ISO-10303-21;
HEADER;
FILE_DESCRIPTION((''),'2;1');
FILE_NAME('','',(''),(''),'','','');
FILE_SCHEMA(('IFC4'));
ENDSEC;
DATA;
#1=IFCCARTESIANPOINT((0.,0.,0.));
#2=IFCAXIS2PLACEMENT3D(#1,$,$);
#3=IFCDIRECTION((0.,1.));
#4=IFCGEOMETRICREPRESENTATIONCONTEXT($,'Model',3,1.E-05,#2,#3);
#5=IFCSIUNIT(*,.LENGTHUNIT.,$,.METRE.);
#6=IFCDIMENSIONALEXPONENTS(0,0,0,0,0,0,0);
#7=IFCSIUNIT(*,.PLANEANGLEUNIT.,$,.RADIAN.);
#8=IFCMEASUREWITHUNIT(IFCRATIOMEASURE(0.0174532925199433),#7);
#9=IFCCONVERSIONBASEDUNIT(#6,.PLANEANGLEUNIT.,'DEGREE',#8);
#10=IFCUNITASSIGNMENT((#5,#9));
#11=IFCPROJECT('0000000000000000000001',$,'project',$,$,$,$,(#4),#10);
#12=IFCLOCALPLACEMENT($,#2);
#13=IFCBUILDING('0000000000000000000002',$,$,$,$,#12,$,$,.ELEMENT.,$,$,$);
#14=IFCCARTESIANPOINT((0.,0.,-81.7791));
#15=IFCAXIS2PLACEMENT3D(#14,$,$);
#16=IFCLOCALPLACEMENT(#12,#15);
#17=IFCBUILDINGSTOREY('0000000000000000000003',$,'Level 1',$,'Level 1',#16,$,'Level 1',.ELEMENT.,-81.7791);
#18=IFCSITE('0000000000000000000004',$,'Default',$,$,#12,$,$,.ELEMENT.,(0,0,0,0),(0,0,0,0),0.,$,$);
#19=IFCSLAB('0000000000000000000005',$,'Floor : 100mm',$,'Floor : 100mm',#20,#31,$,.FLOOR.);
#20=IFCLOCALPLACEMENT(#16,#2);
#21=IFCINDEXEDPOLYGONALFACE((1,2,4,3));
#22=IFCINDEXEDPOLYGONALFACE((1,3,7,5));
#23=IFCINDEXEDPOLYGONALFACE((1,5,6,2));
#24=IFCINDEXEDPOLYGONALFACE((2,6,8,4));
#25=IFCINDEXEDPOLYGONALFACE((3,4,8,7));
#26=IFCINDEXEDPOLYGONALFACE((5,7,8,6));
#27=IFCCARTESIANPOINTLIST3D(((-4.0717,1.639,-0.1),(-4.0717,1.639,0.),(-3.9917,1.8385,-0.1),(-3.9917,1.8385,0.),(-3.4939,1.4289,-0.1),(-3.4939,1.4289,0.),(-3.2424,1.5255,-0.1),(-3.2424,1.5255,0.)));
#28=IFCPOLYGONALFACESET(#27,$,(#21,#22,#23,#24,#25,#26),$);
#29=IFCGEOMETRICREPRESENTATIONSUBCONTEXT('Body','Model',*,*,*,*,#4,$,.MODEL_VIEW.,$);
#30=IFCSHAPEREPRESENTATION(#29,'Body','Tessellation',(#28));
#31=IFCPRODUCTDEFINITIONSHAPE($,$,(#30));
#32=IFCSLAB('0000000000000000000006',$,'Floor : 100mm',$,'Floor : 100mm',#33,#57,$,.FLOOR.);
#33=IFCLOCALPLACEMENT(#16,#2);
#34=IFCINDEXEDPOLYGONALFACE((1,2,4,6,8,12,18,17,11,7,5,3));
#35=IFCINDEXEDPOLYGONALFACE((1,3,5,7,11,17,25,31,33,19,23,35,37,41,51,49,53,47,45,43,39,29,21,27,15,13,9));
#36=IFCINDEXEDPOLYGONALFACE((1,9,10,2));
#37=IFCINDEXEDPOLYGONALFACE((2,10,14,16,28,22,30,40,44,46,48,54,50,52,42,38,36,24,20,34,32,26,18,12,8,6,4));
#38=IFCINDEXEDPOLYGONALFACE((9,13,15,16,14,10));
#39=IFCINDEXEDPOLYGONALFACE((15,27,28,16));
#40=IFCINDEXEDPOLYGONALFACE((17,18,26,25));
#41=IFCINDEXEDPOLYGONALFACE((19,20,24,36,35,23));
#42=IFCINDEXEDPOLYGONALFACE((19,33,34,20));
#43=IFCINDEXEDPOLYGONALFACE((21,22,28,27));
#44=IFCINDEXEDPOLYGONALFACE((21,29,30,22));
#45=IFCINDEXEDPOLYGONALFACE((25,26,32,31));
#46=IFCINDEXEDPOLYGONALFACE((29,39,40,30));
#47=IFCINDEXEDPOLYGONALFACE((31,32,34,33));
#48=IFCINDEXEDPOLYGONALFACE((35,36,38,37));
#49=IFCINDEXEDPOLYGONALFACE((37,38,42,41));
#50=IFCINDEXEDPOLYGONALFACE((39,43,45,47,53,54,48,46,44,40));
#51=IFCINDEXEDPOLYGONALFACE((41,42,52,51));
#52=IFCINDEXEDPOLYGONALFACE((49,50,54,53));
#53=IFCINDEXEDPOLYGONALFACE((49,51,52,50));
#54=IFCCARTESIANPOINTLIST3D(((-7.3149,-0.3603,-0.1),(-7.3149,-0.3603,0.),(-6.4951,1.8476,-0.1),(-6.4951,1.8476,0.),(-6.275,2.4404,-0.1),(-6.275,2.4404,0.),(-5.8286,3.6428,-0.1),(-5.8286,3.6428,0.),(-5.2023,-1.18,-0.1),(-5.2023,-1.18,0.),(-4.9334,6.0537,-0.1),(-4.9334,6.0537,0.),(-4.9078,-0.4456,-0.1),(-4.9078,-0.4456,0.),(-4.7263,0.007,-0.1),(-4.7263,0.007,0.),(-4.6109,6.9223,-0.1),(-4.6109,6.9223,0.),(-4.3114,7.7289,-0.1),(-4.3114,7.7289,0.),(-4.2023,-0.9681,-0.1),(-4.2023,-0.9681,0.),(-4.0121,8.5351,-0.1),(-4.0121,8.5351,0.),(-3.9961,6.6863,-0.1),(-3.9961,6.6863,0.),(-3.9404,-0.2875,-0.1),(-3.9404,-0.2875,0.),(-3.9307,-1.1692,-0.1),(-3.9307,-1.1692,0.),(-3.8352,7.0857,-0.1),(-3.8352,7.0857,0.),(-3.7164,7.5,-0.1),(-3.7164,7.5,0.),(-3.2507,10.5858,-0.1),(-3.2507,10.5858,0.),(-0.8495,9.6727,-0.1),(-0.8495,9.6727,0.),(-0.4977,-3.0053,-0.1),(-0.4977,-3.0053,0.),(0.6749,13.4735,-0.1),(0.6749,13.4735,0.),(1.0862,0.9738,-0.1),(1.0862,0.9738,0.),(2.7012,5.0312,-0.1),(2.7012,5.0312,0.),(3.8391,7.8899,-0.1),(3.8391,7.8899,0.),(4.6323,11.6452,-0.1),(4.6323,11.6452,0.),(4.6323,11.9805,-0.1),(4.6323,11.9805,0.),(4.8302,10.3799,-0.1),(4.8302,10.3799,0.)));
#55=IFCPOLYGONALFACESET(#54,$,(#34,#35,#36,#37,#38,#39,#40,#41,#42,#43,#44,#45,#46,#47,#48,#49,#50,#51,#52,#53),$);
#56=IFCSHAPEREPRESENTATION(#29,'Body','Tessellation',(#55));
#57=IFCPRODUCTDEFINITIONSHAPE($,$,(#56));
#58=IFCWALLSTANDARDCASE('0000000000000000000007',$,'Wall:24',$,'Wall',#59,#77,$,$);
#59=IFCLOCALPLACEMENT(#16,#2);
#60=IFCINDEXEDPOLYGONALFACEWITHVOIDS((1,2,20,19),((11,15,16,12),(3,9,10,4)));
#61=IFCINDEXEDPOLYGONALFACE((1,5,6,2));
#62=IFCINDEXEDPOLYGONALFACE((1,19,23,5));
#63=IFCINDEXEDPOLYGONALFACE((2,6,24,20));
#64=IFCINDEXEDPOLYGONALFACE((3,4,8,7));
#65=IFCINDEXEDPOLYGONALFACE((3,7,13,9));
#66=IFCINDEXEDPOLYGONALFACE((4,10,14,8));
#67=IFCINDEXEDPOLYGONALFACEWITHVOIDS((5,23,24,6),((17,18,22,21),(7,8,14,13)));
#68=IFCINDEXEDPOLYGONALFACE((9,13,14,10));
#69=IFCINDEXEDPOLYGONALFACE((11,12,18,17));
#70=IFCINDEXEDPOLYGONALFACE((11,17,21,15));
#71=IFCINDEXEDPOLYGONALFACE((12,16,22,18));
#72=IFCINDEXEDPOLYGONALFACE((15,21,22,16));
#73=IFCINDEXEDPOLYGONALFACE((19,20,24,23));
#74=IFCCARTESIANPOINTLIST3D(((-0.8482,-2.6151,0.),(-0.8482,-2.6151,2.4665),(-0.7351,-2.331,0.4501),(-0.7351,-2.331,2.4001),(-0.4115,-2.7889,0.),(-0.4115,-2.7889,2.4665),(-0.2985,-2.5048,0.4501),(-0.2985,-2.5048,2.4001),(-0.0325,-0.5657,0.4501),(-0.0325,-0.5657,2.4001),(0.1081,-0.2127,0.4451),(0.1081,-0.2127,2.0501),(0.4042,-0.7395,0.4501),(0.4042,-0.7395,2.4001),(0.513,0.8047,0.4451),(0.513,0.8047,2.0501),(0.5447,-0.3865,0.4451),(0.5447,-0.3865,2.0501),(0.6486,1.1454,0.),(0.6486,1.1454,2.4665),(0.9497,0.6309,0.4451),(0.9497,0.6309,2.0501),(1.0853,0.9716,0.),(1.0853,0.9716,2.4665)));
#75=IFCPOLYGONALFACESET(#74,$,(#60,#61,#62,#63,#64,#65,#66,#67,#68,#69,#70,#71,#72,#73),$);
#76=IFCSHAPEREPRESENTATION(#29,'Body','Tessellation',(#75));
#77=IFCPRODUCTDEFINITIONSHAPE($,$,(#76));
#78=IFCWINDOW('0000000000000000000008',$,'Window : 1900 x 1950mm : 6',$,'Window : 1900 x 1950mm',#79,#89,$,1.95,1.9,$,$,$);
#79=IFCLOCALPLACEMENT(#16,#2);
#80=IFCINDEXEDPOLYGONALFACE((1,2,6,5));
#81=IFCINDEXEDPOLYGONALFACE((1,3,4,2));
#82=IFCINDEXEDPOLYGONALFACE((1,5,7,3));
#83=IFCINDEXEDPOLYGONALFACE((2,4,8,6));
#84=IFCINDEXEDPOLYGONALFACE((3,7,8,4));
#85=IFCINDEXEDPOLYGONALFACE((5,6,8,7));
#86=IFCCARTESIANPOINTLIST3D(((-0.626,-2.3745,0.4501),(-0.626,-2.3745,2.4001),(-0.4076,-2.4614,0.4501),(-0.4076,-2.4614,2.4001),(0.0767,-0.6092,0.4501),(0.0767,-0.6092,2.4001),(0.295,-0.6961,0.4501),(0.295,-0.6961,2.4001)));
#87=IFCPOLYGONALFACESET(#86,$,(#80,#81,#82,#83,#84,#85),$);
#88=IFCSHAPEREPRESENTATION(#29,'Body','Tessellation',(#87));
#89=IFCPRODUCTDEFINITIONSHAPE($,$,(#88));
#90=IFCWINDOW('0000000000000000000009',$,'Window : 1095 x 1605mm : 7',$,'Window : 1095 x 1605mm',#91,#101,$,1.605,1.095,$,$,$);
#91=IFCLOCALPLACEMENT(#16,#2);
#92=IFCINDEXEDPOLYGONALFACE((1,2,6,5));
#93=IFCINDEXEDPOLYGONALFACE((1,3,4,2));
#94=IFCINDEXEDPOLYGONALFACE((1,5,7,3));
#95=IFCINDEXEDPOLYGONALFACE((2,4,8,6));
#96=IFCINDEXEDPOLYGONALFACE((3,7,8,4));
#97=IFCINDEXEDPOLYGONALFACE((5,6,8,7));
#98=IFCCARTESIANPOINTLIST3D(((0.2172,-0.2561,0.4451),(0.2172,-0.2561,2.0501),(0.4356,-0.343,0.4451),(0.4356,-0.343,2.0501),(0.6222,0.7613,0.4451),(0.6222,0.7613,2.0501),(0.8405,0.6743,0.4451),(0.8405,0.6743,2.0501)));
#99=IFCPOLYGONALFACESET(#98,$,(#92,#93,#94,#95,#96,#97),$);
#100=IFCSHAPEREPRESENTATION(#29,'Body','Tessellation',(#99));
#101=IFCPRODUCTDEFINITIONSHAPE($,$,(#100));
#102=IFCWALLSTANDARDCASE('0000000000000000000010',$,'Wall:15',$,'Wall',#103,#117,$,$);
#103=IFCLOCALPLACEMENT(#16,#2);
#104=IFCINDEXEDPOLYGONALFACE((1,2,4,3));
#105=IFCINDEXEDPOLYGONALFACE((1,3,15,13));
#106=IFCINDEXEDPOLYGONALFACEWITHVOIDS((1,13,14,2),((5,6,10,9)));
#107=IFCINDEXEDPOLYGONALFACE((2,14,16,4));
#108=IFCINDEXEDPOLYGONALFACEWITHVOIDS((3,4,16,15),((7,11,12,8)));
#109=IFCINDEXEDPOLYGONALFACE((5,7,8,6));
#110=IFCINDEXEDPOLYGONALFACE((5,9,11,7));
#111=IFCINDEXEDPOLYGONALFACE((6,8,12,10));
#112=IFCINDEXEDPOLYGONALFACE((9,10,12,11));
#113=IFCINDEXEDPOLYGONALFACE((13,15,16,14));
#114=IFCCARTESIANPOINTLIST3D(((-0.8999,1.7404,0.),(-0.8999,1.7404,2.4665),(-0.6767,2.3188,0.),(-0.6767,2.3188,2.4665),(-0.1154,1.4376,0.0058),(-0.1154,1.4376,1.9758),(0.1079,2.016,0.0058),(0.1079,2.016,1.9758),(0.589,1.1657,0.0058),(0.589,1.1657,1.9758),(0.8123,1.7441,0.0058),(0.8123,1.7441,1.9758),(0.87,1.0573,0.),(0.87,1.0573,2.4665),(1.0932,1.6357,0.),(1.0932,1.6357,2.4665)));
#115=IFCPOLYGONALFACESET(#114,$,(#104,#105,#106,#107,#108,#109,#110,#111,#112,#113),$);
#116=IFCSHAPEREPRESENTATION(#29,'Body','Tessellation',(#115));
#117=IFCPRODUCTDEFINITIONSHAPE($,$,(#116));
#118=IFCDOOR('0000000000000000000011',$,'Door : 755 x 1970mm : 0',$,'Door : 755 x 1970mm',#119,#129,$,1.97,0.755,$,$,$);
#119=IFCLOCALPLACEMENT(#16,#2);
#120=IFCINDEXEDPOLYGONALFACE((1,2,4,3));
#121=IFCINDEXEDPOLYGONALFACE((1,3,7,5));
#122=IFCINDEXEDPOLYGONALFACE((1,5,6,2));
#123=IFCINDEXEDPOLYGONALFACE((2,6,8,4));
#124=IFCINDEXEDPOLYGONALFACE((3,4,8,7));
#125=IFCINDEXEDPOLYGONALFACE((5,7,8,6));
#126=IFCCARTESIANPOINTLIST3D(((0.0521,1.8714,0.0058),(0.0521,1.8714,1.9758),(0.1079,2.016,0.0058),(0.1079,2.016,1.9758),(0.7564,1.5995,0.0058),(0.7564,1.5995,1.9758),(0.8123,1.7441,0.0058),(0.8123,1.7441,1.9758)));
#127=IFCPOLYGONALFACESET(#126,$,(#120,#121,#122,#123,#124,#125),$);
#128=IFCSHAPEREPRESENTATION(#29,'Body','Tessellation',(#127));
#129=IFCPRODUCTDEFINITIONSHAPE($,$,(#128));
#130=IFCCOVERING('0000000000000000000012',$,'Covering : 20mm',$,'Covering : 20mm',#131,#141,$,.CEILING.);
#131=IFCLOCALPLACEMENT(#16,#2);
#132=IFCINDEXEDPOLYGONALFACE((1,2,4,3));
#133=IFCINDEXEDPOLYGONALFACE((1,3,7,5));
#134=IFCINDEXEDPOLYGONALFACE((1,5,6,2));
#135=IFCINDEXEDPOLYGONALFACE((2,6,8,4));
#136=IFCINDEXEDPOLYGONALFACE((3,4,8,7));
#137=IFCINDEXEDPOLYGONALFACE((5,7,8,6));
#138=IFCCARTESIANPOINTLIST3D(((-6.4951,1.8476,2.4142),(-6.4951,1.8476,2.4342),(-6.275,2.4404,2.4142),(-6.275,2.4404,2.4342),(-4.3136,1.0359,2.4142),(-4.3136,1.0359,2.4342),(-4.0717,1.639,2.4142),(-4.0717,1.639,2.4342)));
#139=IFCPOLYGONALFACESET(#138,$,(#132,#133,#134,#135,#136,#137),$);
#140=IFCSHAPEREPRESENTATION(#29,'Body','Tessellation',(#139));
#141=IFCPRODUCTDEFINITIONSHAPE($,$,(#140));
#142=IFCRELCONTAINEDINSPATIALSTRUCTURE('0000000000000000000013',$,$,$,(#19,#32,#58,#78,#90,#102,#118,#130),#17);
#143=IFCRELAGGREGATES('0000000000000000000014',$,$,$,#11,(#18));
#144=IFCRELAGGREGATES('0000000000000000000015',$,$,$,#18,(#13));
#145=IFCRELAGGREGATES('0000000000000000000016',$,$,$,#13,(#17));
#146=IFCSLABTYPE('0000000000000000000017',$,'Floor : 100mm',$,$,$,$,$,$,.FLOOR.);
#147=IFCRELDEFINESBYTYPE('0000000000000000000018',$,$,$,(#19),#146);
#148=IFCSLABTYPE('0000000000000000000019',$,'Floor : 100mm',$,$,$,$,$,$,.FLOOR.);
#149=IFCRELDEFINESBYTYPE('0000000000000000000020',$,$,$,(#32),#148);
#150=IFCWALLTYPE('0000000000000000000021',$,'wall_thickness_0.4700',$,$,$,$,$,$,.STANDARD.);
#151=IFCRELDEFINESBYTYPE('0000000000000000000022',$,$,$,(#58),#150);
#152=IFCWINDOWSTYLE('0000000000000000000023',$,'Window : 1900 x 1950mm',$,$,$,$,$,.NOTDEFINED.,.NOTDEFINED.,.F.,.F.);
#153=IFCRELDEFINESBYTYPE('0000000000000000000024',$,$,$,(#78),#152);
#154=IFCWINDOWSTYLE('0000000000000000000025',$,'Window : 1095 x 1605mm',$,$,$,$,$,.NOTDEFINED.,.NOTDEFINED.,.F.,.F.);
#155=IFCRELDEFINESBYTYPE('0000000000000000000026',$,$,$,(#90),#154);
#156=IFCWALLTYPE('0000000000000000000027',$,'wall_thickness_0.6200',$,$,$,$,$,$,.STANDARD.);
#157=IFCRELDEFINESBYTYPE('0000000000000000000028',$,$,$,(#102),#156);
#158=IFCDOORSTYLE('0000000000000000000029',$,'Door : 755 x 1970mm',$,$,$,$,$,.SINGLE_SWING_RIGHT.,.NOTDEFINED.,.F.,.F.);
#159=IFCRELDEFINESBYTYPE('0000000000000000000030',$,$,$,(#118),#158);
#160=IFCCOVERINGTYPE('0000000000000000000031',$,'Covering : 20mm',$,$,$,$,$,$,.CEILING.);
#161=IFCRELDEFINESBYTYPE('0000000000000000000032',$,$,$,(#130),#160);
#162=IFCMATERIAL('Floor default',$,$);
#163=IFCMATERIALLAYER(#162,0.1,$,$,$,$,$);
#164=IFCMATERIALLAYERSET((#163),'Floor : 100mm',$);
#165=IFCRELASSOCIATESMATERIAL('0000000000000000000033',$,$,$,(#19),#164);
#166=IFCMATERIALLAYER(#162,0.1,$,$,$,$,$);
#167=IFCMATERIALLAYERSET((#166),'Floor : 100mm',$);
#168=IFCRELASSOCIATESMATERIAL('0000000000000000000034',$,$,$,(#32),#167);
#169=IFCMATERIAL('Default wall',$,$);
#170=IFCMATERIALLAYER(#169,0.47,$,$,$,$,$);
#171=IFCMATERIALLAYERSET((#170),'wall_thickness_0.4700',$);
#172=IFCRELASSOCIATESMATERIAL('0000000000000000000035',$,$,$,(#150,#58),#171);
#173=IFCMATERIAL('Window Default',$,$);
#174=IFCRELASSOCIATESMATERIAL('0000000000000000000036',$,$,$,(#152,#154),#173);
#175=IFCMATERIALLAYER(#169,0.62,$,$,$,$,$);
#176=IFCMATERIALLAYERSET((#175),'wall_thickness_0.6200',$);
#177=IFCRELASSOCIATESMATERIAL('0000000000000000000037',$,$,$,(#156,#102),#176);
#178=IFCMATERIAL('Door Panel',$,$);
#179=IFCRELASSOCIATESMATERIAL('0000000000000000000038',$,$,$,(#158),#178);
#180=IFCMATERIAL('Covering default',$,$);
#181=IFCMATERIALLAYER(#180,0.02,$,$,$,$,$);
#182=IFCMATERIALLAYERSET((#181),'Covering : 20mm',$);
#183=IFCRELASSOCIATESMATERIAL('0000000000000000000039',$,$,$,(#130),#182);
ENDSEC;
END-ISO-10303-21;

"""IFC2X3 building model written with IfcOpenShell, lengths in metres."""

from ifc_helpers import new_model, entity, si_unit, converted_unit, direction, frame, frame_2d, origin, origin_with_axes, origin_2d_with_axis, place, context, subcontext, project, spatial, polyline, rectangle, outline, extrude, source, transform, mapped, material, layer, layer_set, layer_usage, type_object, type_shapes, element, fill, save


model = new_model("IFC2X3")

# Units and contexts
model_context = context("Model", 3, precision=1e-05, world=origin(), true_north=direction((0.0, 1.0)))
body_context = subcontext(model_context, "Body", "Model", "MODEL_VIEW")
ifc_project = project(units=[si_unit("LENGTHUNIT", "METRE"), converted_unit("PLANEANGLEUNIT", "DEGREE", entity("IfcRatioMeasure", 0.0174532925199433), si_unit("PLANEANGLEUNIT", "RADIAN"), dimensions=[0, 0, 0, 0, 0, 0, 0])], contexts=[model_context])

# Site, building, storey
placement = place(None, origin())
site = spatial("IfcSite", under=ifc_project, at=placement, Name="Default", CompositionType="ELEMENT", RefLatitude=(0, 0, 0, 0), RefLongitude=(0, 0, 0, 0), RefElevation=0.0)
building = spatial("IfcBuilding", under=site, at=placement, CompositionType="ELEMENT")
storey_placement = place(placement, frame((0.0, 0.0, -81.7791)))
storey = spatial("IfcBuildingStorey", under=building, at=storey_placement, Name="Level 1", ObjectType="Level 1", LongName="Level 1", CompositionType="ELEMENT", Elevation=-81.7791)

# Slabs
ifc_material_1 = material(Name="Floor default")
ifc_layer_1 = layer(ifc_material_1, 0.1)
ifc_layer_set_1 = layer_set([ifc_layer_1], Name="Floor : 100mm")
ifc_layer_usage_1 = layer_usage(ifc_layer_set_1, "AXIS3", "POSITIVE", 0.0)
slab_type_1 = type_object("IfcSlabType", Name="Floor : 100mm", PredefinedType="FLOOR")
slab_1_placement = place(storey_placement, origin())
element("IfcSlab", 1, at=slab_1_placement, inside=storey, type_object=slab_type_1, material=ifc_layer_usage_1, Name="Floor : 100mm", ObjectType="Floor : 100mm", PredefinedType="FLOOR", context=body_context, shape_type="SweptSolid", body=[
    extrude(outline(polyline([(-3.4939, 1.4289), (-4.0717, 1.639), (-3.9917, 1.8385), (-3.2424, 1.5255), (-3.4939, 1.4289)])), frame((0.0, 0.0, -0.1), z_axis=(0.0, 0.0, 1.0), x_axis=(1.0, 0.0, 0.0)), (0.0, 0.0, 1.0), 0.1),
])
ifc_layer_2 = layer(ifc_material_1, 0.1)
ifc_layer_set_2 = layer_set([ifc_layer_2], Name="Floor : 100mm")
ifc_layer_usage_2 = layer_usage(ifc_layer_set_2, "AXIS3", "POSITIVE", 0.0)
slab_type_2 = type_object("IfcSlabType", Name="Floor : 100mm", PredefinedType="FLOOR")
slab_2_placement = place(storey_placement, origin())
element("IfcSlab", 2, at=slab_2_placement, inside=storey, type_object=slab_type_2, material=ifc_layer_usage_2, Name="Floor : 100mm", ObjectType="Floor : 100mm", PredefinedType="FLOOR", context=body_context, shape_type="SweptSolid", body=[
    extrude(outline(polyline([(-0.4977, -3.0053), (1.0862, 0.9738), (2.7012, 5.0312), (3.8391, 7.8899), (4.8302, 10.3799), (4.6323, 11.6452), (4.6323, 11.9805), (0.6749, 13.4735), (-0.8495, 9.6727), (-3.2507, 10.5858), (-4.0121, 8.5351), (-4.3114, 7.7289), (-3.7164, 7.5), (-3.8352, 7.0857), (-3.9961, 6.6863), (-4.6109, 6.9223), (-4.9334, 6.0537), (-5.8286, 3.6428), (-6.275, 2.4404), (-6.4951, 1.8476), (-7.3149, -0.3603), (-5.2023, -1.18), (-4.9078, -0.4456), (-4.7263, 0.007), (-3.9404, -0.2875), (-4.2023, -0.9681), (-3.9307, -1.1692), (-0.4977, -3.0053)])), frame((0.0, 0.0, -0.1), z_axis=(0.0, 0.0, 1.0), x_axis=(1.0, 0.0, 0.0)), (0.0, 0.0, 1.0), 0.1),
])

# Wall, openings, windows
ifc_material_2 = material(Name="Default wall")
ifc_layer_3 = layer(ifc_material_2, 0.47)
ifc_layer_set_3 = layer_set([ifc_layer_3], Name="wall_thickness_0.4700")
ifc_layer_usage_3 = layer_usage(ifc_layer_set_3, "AXIS2", "POSITIVE", -0.235)
wall_type_1 = type_object("IfcWallType", Name="wall_thickness_0.4700", PredefinedType="STANDARD", material=ifc_layer_set_3)
wall_1_placement = place(storey_placement, frame((0.867, 1.0585, 0.0), z_axis=(0.0, 0.0, 1.0), x_axis=(-0.36982, -0.929103, 0.0)))
wall_1 = element("IfcWallStandardCase", 3, at=wall_1_placement, inside=storey, type_object=wall_type_1, material=ifc_layer_usage_3, Name="Wall:24", ObjectType="Wall", context=body_context, shape_type="SweptSolid", body=[
    extrude(outline(polyline([(4.0474, -0.235), (4.0474, 0.235), (0.0, 0.235), (0.0, -0.235), (4.0474, -0.235)])), origin(), (0.0, 0.0, 1.0), 2.4665),
])
opening_1_placement = place(wall_1_placement, frame((1.8417, -0.235, 0.4501)))
opening_1 = element("IfcOpeningElement", 4, at=opening_1_placement, cuts=wall_1, ObjectType="Opening", context=body_context, shape_type="SweptSolid", body=[
    extrude(rectangle(XDim=1.9, YDim=1.95, at=frame_2d((0.975, 0.95), x_axis=(0.0, 1.0))), frame((0.0, 0.0, 0.0), z_axis=(0.0, 1.0, 0.0), x_axis=(0.0, 0.0, 1.0)), (0.0, 0.0, 1.0), 0.47),
])
opening_2_placement = place(wall_1_placement, frame((0.3667, -0.235, 0.4451)))
opening_2 = element("IfcOpeningElement", 5, at=opening_2_placement, cuts=wall_1, ObjectType="Opening", context=body_context, shape_type="SweptSolid", body=[
    extrude(rectangle(XDim=1.095, YDim=1.605, at=frame_2d((0.8025, 0.5475), x_axis=(0.0, 1.0))), frame((0.0, 0.0, 0.0), z_axis=(0.0, 1.0, 0.0), x_axis=(0.0, 0.0, 1.0)), (0.0, 0.0, 1.0), 0.47),
])
ifc_material_3 = material(Name="Window Default")
window_style_1 = type_object("IfcWindowStyle", Name="Window : 1900 x 1950mm", ConstructionType="NOTDEFINED", OperationType="NOTDEFINED", ParameterTakesPrecedence=False, Sizeable=False, material=ifc_material_3)
shared_shape_1 = source(origin(), body_context, "Body", "SweptSolid", [
    extrude(rectangle(XDim=0.235, YDim=1.9, at=origin_2d_with_axis()), frame((0.95, 0.235, 0.0), z_axis=(0.0, 0.0, 1.0), x_axis=(0.0, 1.0, 0.0)), (0.0, 0.0, 1.0), 1.95),
])
type_shapes(window_style_1, [shared_shape_1])
window_1_placement = place(opening_1_placement, origin())
window_1 = element("IfcWindow", 6, at=window_1_placement, inside=storey, type_object=window_style_1, Name="Window : 1900 x 1950mm : 6", ObjectType="Window : 1900 x 1950mm", OverallHeight=1.95, OverallWidth=1.9, context=body_context, shape_type="MappedRepresentation", body=[
    mapped(shared_shape_1, transform((0.0, 0.0, 0.0), scale=1.0)),
])
fill(opening_1, window_1)
window_style_2 = type_object("IfcWindowStyle", Name="Window : 1095 x 1605mm", ConstructionType="NOTDEFINED", OperationType="NOTDEFINED", ParameterTakesPrecedence=False, Sizeable=False, material=ifc_material_3)
shared_shape_2 = source(origin(), body_context, "Body", "SweptSolid", [
    extrude(rectangle(XDim=0.235, YDim=1.095, at=origin_2d_with_axis()), frame((0.5475, 0.235, 0.0), z_axis=(0.0, 0.0, 1.0), x_axis=(0.0, 1.0, 0.0)), (0.0, 0.0, 1.0), 1.605),
])
type_shapes(window_style_2, [shared_shape_2])
window_2_placement = place(opening_2_placement, origin())
window_2 = element("IfcWindow", 7, at=window_2_placement, inside=storey, type_object=window_style_2, Name="Window : 1095 x 1605mm : 7", ObjectType="Window : 1095 x 1605mm", OverallHeight=1.605, OverallWidth=1.095, context=body_context, shape_type="MappedRepresentation", body=[
    mapped(shared_shape_2, transform((0.0, 0.0, 0.0), scale=1.0)),
])
fill(opening_2, window_2)

# Wall, opening, door
ifc_layer_4 = layer(ifc_material_2, 0.62)
ifc_layer_set_4 = layer_set([ifc_layer_4], Name="wall_thickness_0.6200")
ifc_layer_usage_4 = layer_usage(ifc_layer_set_4, "AXIS2", "POSITIVE", -0.31)
wall_type_2 = type_object("IfcWallType", Name="wall_thickness_0.6200", PredefinedType="STANDARD", material=ifc_layer_set_4)
wall_2_placement = place(storey_placement, frame((-0.7883, 2.0296, 0.0), z_axis=(0.0, 0.0, 1.0), x_axis=(0.93292, -0.360083, 0.0)))
wall_2 = element("IfcWallStandardCase", 8, at=wall_2_placement, inside=storey, type_object=wall_type_2, material=ifc_layer_usage_4, Name="Wall:15", ObjectType="Wall", context=body_context, shape_type="SweptSolid", body=[
    extrude(outline(polyline([(1.8972, -0.31), (1.8972, 0.31), (0.0, 0.31), (0.0, -0.31), (1.8972, -0.31)])), origin(), (0.0, 0.0, 1.0), 2.4665),
])
opening_3_placement = place(wall_2_placement, frame((0.841, -0.31, 0.0058)))
opening_3 = element("IfcOpeningElement", 9, at=opening_3_placement, cuts=wall_2, ObjectType="Opening", context=body_context, shape_type="SweptSolid", body=[
    extrude(rectangle(XDim=0.755, YDim=1.97, at=frame_2d((0.985, 0.3775), x_axis=(0.0, 1.0))), frame((0.0, 0.0, 0.0), z_axis=(0.0, 1.0, 0.0), x_axis=(0.0, 0.0, 1.0)), (0.0, 0.0, 1.0), 0.62),
])
ifc_material_4 = material(Name="Door Panel")
door_style = type_object("IfcDoorStyle", Name="Door : 755 x 1970mm", ConstructionType="NOTDEFINED", OperationType="SINGLE_SWING_RIGHT", ParameterTakesPrecedence=False, Sizeable=False, material=ifc_material_4)
shared_shape_3 = source(origin(), body_context, "Body", "SweptSolid", [
    extrude(rectangle(XDim=0.155, YDim=0.755, at=origin_2d_with_axis()), frame((0.3775, 0.5425, 0.0), z_axis=(0.0, 0.0, 1.0), x_axis=(0.0, 1.0, 0.0)), (0.0, 0.0, 1.0), 1.97),
])
type_shapes(door_style, [shared_shape_3])
door_placement = place(opening_3_placement, origin())
door = element("IfcDoor", 10, at=door_placement, inside=storey, type_object=door_style, Name="Door : 755 x 1970mm : 0", ObjectType="Door : 755 x 1970mm", OverallHeight=1.97, OverallWidth=0.755, context=body_context, shape_type="MappedRepresentation", body=[
    mapped(shared_shape_3, transform((0.0, 0.0, 0.0), scale=1.0)),
])
fill(opening_3, door)

# Covering
ifc_material_5 = material(Name="Covering default")
ifc_layer_5 = layer(ifc_material_5, 0.02)
ifc_layer_set_5 = layer_set([ifc_layer_5], Name="Covering : 20mm")
ifc_layer_usage_5 = layer_usage(ifc_layer_set_5, "AXIS3", "POSITIVE", 0.0)
covering_type_1 = type_object("IfcCoveringType", Name="Covering : 20mm", PredefinedType="CEILING")
covering_1_placement = place(placement, frame((0.0, 0.0, -79.3649)))
element("IfcCovering", 11, at=covering_1_placement, inside=storey, type_object=covering_type_1, material=ifc_layer_usage_5, Name="Covering : 20mm", ObjectType="Covering : 20mm", PredefinedType="CEILING", context=body_context, shape_type="SweptSolid", body=[
    extrude(outline(polyline([(-6.275, 2.4404), (-4.0717, 1.639), (-4.3136, 1.0359), (-6.4951, 1.8476), (-6.275, 2.4404)])), origin_with_axes(), (0.0, 0.0, 1.0), 0.02),
])

save(model, "model.ifc")
